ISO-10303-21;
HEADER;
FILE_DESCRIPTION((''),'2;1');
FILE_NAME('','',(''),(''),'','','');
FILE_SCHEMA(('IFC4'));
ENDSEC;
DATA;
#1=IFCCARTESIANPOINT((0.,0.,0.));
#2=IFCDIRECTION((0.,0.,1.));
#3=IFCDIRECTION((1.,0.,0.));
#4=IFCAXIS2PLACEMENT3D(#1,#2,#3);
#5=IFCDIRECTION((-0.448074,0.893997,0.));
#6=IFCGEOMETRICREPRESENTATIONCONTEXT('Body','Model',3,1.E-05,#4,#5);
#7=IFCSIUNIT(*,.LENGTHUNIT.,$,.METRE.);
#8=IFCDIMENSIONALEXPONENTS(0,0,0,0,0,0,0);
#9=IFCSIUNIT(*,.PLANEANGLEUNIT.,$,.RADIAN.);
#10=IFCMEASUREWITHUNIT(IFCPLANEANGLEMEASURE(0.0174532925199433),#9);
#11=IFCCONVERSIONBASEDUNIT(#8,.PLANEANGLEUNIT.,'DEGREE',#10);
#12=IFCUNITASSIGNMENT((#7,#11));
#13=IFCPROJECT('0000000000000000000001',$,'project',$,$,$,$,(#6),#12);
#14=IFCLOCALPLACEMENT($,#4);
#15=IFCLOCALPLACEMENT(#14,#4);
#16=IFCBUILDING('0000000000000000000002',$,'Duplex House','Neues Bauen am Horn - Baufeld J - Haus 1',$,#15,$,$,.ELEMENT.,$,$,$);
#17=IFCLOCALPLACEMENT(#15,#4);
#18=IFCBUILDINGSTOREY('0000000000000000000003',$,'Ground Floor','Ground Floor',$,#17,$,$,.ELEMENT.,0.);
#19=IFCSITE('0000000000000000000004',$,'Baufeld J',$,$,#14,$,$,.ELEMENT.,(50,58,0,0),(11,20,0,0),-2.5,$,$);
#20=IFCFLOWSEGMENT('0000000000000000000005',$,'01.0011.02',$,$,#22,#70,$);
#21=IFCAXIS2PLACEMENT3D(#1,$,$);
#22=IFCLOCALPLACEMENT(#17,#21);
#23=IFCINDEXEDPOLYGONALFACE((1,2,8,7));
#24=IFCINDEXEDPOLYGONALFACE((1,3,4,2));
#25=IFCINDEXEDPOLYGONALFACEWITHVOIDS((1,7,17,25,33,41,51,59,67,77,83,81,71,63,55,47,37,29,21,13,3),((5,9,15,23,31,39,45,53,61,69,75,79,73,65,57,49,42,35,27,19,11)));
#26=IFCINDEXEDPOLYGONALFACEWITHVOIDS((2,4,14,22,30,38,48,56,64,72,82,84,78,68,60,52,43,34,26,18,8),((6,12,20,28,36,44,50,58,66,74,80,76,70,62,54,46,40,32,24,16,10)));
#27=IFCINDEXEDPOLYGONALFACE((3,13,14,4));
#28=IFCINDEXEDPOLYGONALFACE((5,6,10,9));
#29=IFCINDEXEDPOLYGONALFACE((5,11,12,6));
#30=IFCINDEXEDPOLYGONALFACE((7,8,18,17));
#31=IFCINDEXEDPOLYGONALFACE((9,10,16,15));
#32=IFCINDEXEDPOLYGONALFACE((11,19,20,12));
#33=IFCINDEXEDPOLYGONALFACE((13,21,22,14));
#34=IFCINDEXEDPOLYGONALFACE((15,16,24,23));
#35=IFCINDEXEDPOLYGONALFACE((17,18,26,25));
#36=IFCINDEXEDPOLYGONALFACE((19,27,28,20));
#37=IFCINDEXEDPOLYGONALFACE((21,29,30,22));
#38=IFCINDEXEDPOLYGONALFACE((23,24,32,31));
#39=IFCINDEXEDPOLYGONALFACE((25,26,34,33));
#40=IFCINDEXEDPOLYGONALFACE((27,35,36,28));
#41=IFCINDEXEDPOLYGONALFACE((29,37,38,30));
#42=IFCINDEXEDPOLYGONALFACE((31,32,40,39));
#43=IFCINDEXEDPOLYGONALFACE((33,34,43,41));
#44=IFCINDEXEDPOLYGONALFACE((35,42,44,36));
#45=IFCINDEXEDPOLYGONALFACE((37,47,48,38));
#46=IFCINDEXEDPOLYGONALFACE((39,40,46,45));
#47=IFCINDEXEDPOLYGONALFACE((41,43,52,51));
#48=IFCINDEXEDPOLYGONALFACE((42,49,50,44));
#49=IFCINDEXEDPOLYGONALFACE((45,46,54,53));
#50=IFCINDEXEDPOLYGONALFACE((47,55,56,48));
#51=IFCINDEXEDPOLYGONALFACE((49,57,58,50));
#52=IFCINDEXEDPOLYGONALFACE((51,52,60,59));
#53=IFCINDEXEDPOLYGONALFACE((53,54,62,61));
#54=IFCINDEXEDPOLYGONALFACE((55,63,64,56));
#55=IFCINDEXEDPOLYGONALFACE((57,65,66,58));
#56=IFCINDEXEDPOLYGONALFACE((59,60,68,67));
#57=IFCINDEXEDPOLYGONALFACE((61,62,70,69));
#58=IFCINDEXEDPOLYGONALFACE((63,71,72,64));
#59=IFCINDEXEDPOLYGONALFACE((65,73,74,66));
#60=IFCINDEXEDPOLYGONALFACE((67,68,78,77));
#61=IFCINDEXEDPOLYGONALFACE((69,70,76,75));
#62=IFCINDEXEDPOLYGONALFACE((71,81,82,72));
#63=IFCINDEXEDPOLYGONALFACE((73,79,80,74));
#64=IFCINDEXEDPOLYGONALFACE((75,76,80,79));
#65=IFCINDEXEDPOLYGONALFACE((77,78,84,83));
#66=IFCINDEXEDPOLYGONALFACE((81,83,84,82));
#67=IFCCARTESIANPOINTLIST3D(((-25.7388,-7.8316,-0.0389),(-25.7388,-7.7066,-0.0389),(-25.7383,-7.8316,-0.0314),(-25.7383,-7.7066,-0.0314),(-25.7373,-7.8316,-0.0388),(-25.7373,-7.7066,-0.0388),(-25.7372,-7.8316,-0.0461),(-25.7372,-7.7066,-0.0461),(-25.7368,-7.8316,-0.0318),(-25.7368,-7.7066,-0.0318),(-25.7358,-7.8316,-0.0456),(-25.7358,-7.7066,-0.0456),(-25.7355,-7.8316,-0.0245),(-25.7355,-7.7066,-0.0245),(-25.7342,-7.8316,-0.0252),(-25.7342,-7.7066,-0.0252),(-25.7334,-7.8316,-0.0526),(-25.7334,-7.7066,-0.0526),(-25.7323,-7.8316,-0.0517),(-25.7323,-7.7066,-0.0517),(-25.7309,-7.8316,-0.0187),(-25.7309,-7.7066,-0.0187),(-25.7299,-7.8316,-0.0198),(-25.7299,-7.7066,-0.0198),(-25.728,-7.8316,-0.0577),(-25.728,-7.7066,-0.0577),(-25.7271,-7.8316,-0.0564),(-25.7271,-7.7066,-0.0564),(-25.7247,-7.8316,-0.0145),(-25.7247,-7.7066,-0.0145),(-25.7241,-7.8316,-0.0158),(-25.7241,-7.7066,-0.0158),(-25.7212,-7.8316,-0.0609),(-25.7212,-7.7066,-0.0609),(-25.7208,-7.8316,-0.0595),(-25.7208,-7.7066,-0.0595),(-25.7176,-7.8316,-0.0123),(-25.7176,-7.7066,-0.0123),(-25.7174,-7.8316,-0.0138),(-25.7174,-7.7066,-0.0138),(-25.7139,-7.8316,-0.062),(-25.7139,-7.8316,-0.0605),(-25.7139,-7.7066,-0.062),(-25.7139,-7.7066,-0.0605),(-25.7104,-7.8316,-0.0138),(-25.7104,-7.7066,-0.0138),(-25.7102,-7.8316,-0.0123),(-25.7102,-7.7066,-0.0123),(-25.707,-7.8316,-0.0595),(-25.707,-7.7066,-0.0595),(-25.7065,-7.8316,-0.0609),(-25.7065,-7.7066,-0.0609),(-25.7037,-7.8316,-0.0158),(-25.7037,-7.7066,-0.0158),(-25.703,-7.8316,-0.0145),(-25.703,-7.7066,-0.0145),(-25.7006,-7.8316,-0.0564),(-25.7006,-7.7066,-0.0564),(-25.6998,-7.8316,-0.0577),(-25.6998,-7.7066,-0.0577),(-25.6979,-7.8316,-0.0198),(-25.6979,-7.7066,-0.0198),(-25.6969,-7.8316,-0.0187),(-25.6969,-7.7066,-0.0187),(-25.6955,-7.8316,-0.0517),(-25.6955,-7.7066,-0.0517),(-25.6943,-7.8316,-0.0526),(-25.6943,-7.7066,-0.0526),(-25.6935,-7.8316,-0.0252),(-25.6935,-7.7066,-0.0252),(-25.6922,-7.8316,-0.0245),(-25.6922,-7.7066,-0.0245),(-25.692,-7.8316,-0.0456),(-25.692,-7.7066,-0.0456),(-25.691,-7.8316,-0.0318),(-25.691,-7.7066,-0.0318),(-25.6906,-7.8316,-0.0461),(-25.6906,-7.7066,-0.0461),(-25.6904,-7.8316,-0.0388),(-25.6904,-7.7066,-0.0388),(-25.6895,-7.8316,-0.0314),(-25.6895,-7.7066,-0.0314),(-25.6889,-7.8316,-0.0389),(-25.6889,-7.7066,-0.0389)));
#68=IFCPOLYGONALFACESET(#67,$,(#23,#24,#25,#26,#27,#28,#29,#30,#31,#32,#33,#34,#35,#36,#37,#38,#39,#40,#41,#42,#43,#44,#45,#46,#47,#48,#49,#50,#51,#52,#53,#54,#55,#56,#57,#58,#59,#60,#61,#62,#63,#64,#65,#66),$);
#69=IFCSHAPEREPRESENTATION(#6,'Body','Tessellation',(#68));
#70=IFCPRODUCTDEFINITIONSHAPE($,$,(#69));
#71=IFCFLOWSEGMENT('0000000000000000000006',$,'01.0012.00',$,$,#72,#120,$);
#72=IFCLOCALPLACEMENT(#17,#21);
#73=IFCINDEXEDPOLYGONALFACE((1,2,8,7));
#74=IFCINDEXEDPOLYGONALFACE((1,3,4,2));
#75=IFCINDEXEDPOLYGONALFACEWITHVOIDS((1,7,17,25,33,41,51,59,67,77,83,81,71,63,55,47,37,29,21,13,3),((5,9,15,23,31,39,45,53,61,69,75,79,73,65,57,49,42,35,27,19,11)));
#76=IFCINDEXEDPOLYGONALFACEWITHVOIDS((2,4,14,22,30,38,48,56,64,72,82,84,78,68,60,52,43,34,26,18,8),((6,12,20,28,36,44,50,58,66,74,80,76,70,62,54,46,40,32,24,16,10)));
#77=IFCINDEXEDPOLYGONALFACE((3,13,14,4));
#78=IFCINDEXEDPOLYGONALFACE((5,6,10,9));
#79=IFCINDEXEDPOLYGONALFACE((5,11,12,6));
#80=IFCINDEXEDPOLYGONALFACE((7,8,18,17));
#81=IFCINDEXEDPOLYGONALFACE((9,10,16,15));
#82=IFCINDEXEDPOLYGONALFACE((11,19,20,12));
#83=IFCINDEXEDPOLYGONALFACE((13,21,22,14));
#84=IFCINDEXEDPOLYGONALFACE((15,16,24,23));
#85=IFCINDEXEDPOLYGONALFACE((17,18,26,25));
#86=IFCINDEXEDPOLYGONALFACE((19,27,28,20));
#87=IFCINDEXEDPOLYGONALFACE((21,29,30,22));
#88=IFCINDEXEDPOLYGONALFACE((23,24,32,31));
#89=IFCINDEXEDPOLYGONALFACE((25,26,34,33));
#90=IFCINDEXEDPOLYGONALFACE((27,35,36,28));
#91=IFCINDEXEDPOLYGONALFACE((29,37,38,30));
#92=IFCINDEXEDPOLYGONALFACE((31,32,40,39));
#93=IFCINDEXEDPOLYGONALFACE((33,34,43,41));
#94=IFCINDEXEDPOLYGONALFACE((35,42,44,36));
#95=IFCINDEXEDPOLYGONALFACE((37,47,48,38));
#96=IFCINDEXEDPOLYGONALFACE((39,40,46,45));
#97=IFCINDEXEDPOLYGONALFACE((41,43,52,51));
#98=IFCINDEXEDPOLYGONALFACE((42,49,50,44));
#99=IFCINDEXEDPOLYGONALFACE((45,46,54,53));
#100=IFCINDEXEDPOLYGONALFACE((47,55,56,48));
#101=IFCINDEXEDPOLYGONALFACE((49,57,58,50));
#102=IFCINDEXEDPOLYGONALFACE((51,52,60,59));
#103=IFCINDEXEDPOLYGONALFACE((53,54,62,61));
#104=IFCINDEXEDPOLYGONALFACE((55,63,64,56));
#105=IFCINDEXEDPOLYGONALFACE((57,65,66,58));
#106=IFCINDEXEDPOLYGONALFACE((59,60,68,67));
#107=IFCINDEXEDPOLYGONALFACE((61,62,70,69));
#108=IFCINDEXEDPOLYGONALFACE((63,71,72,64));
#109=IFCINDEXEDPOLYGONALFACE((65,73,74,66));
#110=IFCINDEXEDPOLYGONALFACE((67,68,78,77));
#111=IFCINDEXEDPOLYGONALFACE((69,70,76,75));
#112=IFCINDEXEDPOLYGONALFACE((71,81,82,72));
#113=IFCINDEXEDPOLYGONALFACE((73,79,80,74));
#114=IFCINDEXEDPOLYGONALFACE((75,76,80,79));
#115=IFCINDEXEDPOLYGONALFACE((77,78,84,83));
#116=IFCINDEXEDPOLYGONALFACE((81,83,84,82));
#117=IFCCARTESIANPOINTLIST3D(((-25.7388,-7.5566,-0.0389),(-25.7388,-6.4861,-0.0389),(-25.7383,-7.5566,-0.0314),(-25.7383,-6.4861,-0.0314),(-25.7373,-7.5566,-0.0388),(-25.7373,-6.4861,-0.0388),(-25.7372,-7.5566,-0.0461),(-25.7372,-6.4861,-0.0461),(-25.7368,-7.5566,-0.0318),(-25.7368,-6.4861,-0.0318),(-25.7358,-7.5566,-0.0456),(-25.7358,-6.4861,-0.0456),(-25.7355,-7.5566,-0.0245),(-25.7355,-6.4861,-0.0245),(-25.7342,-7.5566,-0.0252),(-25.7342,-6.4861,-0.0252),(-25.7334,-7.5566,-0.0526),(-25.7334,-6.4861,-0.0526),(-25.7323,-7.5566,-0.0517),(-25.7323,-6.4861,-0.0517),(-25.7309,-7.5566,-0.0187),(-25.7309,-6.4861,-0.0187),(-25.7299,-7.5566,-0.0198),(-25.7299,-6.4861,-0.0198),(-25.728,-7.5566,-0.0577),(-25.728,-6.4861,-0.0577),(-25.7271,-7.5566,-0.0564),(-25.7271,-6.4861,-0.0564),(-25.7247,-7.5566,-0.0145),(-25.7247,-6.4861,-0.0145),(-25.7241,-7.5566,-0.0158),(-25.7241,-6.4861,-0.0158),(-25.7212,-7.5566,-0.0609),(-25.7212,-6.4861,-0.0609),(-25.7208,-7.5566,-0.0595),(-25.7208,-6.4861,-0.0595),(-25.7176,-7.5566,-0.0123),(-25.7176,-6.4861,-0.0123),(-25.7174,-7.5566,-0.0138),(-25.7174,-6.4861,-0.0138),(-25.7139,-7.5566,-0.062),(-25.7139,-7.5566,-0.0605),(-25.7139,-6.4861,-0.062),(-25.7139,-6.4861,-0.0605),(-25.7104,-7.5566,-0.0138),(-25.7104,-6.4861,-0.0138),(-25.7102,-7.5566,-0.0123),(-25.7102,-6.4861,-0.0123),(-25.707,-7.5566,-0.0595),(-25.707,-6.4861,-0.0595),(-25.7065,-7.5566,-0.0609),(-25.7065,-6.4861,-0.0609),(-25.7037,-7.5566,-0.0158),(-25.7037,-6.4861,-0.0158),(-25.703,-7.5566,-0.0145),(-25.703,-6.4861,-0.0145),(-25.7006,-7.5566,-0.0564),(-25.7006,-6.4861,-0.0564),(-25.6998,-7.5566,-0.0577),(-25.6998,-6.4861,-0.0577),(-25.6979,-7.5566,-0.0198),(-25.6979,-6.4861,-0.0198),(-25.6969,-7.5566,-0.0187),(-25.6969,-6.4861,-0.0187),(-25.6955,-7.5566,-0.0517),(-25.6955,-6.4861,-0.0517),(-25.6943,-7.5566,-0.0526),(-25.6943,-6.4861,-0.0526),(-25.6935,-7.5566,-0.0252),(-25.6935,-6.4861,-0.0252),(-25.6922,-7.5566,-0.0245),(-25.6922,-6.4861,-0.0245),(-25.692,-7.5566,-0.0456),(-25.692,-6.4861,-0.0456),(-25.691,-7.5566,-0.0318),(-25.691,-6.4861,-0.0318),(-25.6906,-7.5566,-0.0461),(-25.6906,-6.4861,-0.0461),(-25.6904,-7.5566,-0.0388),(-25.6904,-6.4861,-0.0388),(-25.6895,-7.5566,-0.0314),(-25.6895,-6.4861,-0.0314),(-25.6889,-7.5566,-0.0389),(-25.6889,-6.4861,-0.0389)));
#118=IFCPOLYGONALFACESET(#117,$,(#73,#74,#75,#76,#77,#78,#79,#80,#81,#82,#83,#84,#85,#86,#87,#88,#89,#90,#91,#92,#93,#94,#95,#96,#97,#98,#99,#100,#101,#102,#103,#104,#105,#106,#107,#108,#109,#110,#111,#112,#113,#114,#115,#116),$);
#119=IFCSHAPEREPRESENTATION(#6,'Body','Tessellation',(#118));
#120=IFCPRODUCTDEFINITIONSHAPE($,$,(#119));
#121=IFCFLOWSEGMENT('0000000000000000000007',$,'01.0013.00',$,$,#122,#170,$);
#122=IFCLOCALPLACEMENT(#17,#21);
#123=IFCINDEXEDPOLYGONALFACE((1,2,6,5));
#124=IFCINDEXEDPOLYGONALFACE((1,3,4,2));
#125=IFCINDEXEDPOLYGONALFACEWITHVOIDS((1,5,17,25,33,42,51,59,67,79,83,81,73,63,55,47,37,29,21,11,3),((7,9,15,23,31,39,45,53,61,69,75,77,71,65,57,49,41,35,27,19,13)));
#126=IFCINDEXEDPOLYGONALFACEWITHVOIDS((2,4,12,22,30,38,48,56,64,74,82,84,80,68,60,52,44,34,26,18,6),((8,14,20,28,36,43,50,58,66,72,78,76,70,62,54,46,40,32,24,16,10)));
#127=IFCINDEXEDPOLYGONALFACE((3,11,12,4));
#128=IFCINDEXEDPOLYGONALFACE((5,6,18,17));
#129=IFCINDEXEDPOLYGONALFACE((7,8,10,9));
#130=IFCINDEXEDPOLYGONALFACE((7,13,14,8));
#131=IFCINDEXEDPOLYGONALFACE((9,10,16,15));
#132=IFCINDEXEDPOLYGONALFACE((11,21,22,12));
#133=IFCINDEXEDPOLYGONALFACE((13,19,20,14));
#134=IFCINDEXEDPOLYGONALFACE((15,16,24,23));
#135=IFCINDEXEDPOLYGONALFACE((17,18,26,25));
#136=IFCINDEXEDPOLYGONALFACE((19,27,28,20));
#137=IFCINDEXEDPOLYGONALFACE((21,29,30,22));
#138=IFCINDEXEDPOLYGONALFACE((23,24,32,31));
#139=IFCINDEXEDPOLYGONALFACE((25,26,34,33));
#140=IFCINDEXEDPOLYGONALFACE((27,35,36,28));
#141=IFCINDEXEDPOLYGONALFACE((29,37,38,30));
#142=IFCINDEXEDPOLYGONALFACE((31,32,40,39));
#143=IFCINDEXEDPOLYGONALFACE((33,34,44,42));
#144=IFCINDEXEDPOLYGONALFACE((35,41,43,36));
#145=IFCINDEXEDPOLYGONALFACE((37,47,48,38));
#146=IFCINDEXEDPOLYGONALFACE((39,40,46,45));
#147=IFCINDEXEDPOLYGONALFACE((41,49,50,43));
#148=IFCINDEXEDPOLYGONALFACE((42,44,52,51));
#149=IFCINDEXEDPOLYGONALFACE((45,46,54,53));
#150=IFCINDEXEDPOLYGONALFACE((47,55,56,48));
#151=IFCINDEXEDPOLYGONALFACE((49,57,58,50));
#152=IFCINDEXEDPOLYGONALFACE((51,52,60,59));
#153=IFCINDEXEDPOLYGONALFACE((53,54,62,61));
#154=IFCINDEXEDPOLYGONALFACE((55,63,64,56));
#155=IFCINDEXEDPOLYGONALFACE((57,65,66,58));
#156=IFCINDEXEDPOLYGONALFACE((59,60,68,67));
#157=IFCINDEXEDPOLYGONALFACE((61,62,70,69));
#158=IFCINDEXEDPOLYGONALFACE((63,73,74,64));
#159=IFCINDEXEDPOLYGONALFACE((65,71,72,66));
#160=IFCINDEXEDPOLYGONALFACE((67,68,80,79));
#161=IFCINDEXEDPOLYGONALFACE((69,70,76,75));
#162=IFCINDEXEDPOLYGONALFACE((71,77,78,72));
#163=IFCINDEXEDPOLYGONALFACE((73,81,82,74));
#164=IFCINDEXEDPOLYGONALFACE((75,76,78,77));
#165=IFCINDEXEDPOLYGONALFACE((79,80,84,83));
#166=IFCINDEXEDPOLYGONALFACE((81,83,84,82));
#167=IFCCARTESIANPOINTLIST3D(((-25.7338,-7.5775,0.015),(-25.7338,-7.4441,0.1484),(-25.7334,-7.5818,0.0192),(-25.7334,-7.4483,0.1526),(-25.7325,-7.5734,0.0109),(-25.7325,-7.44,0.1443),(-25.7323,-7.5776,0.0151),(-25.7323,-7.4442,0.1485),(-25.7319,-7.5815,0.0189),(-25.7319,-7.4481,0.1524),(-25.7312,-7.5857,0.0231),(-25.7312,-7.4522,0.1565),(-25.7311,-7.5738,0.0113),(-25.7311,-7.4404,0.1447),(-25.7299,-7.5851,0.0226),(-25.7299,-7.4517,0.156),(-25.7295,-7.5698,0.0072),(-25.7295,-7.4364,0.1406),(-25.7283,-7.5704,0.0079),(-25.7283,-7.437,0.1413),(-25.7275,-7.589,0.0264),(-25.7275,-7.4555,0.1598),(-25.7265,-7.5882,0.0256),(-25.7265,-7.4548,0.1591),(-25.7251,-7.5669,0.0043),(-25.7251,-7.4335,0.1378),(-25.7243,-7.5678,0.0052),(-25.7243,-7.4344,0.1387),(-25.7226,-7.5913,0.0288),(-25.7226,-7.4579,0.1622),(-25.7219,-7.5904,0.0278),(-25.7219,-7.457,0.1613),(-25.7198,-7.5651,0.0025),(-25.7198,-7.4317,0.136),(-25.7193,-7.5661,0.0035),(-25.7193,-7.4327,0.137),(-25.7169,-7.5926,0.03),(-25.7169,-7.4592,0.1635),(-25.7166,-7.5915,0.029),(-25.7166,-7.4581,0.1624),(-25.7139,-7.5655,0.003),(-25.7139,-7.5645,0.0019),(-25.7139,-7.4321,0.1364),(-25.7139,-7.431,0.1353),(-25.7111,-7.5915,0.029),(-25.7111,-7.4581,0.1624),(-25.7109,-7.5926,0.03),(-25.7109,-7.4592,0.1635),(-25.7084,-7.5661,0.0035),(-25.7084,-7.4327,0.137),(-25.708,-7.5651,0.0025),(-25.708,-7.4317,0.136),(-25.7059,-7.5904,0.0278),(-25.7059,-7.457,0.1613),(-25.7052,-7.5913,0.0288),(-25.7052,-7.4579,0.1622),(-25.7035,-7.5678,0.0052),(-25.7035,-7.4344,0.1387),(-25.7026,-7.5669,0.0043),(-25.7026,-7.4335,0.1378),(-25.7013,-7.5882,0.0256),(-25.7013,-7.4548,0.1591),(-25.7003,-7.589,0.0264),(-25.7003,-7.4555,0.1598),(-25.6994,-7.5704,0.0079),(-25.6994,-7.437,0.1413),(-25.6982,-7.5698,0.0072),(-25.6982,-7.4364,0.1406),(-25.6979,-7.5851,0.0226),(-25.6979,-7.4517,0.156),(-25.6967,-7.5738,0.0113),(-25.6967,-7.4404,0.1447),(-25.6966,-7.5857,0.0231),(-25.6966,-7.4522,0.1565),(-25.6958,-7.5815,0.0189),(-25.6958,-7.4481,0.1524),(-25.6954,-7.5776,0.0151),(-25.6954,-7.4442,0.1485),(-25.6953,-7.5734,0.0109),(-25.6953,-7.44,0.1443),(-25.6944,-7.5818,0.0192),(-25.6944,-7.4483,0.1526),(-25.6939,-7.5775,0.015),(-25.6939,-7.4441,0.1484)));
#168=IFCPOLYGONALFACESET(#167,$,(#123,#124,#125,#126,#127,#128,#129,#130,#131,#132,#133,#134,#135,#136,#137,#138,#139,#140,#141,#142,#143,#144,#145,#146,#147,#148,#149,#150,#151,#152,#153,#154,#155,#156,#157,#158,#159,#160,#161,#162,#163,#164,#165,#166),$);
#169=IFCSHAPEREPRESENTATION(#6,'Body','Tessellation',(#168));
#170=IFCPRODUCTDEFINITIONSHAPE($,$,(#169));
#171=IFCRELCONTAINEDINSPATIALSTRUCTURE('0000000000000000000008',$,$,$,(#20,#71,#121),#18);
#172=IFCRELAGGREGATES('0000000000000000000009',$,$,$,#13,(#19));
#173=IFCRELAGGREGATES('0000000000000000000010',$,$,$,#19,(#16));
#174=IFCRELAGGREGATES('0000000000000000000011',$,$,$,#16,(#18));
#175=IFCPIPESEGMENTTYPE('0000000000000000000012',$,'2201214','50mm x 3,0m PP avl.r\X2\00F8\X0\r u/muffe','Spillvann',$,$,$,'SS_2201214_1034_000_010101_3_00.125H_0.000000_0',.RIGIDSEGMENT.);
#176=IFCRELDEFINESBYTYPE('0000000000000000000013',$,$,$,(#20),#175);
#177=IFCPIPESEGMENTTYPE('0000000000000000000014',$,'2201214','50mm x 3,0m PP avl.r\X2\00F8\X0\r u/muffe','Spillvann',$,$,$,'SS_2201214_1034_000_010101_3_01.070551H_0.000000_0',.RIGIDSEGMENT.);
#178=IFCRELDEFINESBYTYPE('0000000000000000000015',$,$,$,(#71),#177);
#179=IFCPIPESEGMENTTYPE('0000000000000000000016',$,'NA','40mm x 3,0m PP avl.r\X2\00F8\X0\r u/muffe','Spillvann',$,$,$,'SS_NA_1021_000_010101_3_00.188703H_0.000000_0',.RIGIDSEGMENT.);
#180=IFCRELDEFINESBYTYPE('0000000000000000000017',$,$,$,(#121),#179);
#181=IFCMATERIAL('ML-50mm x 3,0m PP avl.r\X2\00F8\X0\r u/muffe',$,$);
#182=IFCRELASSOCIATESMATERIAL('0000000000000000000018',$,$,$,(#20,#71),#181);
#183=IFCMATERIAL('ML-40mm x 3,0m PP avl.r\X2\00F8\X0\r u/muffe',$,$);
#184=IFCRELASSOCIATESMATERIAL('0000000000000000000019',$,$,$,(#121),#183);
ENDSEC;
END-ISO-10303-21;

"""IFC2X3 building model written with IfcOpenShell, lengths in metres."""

from ifc_helpers import new_model, entity, si_unit, converted_unit, direction, frame, origin_with_axes, origin_2d_with_axis, place, context, project, spatial, hollow_circle, extrude, material, type_object, element, save


model = new_model("IFC2X3")

# Units and contexts
model_context = context("Model", 3, precision=1e-05, world=origin_with_axes(), true_north=direction((-0.448074, 0.893997, 0.0)), identifier="Body")
ifc_project = project(units=[si_unit("LENGTHUNIT", "METRE"), converted_unit("PLANEANGLEUNIT", "DEGREE", entity("IfcPlaneAngleMeasure", 0.0174532925199433), si_unit("PLANEANGLEUNIT", "RADIAN"), dimensions=[0, 0, 0, 0, 0, 0, 0])], contexts=[model_context])

# Site, building, storey
site_placement = place(None, origin_with_axes())
site = spatial("IfcSite", under=ifc_project, at=site_placement, Name="Baufeld J", CompositionType="ELEMENT", RefLatitude=(50, 58, 0, 0), RefLongitude=(11, 20, 0, 0), RefElevation=-2.5)
building_placement = place(site_placement, origin_with_axes())
building = spatial("IfcBuilding", under=site, at=building_placement, Name="Duplex House", Description="Neues Bauen am Horn - Baufeld J - Haus 1", CompositionType="ELEMENT")
storey_placement = place(building_placement, origin_with_axes())
storey = spatial("IfcBuildingStorey", under=building, at=storey_placement, Name="Ground Floor", Description="Ground Floor", CompositionType="ELEMENT", Elevation=0.0)

# Flow segments
ifc_material_1 = material(Name="ML-50mm x 3,0m PP avl.rør u/muffe")
pipe_segment_type_1 = type_object("IfcPipeSegmentType", Name="2201214", Description="50mm x 3,0m PP avl.rør u/muffe", ApplicableOccurrence="Spillvann", ElementType="SS_2201214_1034_000_010101_3_00.125H_0.000000_0", PredefinedType="RIGIDSEGMENT")
flow_segment_1_placement = place(storey_placement, frame((-25.7139, -7.8316, -0.037), z_axis=(0.0, 0.0, 1.0), x_axis=(0.0, 1.0, 0.0)))
element("IfcFlowSegment", 1, at=flow_segment_1_placement, inside=storey, type_object=pipe_segment_type_1, material=ifc_material_1, Name="01.0011.02", context=model_context, shape_type="SweptSolid", body=[
    extrude(hollow_circle(Radius=0.025, WallThickness=0.0015, at=origin_2d_with_axis()), frame((0.0, 0.0, 0.0), z_axis=(1.0, 0.0, 0.0), x_axis=(0.0, 0.0, -1.0)), (0.0, 0.0, 1.0), 0.125),
])
pipe_segment_type_2 = type_object("IfcPipeSegmentType", Name="2201214", Description="50mm x 3,0m PP avl.rør u/muffe", ApplicableOccurrence="Spillvann", ElementType="SS_2201214_1034_000_010101_3_01.070551H_0.000000_0", PredefinedType="RIGIDSEGMENT")
flow_segment_2_placement = place(storey_placement, frame((-25.7139, -7.5566, -0.037), z_axis=(0.0, 0.0, 1.0), x_axis=(0.0, 1.0, 0.0)))
element("IfcFlowSegment", 2, at=flow_segment_2_placement, inside=storey, type_object=pipe_segment_type_2, material=ifc_material_1, Name="01.0012.00", context=model_context, shape_type="SweptSolid", body=[
    extrude(hollow_circle(Radius=0.025, WallThickness=0.0015, at=origin_2d_with_axis()), frame((0.0, 0.0, 0.0), z_axis=(1.0, 0.0, 0.0), x_axis=(0.0, 0.0, -1.0)), (0.0, 0.0, 1.0), 1.0706),
])
ifc_material_2 = material(Name="ML-40mm x 3,0m PP avl.rør u/muffe")
pipe_segment_type_3 = type_object("IfcPipeSegmentType", Name="NA", Description="40mm x 3,0m PP avl.rør u/muffe", ApplicableOccurrence="Spillvann", ElementType="SS_NA_1021_000_010101_3_00.188703H_0.000000_0", PredefinedType="RIGIDSEGMENT")
flow_segment_3_placement = place(storey_placement, frame((-25.7139, -7.5786, 0.016), z_axis=(0.0, -0.707107, 0.707107), x_axis=(0.0, 0.707107, 0.707107)))
element("IfcFlowSegment", 3, at=flow_segment_3_placement, inside=storey, type_object=pipe_segment_type_3, material=ifc_material_2, Name="01.0013.00", context=model_context, shape_type="SweptSolid", body=[
    extrude(hollow_circle(Radius=0.02, WallThickness=0.0015, at=origin_2d_with_axis()), frame((0.0, 0.0, 0.0), z_axis=(1.0, 0.0, 0.0), x_axis=(0.0, 0.0, -1.0)), (0.0, 0.0, 1.0), 0.1887),
])

save(model, "model.ifc")
